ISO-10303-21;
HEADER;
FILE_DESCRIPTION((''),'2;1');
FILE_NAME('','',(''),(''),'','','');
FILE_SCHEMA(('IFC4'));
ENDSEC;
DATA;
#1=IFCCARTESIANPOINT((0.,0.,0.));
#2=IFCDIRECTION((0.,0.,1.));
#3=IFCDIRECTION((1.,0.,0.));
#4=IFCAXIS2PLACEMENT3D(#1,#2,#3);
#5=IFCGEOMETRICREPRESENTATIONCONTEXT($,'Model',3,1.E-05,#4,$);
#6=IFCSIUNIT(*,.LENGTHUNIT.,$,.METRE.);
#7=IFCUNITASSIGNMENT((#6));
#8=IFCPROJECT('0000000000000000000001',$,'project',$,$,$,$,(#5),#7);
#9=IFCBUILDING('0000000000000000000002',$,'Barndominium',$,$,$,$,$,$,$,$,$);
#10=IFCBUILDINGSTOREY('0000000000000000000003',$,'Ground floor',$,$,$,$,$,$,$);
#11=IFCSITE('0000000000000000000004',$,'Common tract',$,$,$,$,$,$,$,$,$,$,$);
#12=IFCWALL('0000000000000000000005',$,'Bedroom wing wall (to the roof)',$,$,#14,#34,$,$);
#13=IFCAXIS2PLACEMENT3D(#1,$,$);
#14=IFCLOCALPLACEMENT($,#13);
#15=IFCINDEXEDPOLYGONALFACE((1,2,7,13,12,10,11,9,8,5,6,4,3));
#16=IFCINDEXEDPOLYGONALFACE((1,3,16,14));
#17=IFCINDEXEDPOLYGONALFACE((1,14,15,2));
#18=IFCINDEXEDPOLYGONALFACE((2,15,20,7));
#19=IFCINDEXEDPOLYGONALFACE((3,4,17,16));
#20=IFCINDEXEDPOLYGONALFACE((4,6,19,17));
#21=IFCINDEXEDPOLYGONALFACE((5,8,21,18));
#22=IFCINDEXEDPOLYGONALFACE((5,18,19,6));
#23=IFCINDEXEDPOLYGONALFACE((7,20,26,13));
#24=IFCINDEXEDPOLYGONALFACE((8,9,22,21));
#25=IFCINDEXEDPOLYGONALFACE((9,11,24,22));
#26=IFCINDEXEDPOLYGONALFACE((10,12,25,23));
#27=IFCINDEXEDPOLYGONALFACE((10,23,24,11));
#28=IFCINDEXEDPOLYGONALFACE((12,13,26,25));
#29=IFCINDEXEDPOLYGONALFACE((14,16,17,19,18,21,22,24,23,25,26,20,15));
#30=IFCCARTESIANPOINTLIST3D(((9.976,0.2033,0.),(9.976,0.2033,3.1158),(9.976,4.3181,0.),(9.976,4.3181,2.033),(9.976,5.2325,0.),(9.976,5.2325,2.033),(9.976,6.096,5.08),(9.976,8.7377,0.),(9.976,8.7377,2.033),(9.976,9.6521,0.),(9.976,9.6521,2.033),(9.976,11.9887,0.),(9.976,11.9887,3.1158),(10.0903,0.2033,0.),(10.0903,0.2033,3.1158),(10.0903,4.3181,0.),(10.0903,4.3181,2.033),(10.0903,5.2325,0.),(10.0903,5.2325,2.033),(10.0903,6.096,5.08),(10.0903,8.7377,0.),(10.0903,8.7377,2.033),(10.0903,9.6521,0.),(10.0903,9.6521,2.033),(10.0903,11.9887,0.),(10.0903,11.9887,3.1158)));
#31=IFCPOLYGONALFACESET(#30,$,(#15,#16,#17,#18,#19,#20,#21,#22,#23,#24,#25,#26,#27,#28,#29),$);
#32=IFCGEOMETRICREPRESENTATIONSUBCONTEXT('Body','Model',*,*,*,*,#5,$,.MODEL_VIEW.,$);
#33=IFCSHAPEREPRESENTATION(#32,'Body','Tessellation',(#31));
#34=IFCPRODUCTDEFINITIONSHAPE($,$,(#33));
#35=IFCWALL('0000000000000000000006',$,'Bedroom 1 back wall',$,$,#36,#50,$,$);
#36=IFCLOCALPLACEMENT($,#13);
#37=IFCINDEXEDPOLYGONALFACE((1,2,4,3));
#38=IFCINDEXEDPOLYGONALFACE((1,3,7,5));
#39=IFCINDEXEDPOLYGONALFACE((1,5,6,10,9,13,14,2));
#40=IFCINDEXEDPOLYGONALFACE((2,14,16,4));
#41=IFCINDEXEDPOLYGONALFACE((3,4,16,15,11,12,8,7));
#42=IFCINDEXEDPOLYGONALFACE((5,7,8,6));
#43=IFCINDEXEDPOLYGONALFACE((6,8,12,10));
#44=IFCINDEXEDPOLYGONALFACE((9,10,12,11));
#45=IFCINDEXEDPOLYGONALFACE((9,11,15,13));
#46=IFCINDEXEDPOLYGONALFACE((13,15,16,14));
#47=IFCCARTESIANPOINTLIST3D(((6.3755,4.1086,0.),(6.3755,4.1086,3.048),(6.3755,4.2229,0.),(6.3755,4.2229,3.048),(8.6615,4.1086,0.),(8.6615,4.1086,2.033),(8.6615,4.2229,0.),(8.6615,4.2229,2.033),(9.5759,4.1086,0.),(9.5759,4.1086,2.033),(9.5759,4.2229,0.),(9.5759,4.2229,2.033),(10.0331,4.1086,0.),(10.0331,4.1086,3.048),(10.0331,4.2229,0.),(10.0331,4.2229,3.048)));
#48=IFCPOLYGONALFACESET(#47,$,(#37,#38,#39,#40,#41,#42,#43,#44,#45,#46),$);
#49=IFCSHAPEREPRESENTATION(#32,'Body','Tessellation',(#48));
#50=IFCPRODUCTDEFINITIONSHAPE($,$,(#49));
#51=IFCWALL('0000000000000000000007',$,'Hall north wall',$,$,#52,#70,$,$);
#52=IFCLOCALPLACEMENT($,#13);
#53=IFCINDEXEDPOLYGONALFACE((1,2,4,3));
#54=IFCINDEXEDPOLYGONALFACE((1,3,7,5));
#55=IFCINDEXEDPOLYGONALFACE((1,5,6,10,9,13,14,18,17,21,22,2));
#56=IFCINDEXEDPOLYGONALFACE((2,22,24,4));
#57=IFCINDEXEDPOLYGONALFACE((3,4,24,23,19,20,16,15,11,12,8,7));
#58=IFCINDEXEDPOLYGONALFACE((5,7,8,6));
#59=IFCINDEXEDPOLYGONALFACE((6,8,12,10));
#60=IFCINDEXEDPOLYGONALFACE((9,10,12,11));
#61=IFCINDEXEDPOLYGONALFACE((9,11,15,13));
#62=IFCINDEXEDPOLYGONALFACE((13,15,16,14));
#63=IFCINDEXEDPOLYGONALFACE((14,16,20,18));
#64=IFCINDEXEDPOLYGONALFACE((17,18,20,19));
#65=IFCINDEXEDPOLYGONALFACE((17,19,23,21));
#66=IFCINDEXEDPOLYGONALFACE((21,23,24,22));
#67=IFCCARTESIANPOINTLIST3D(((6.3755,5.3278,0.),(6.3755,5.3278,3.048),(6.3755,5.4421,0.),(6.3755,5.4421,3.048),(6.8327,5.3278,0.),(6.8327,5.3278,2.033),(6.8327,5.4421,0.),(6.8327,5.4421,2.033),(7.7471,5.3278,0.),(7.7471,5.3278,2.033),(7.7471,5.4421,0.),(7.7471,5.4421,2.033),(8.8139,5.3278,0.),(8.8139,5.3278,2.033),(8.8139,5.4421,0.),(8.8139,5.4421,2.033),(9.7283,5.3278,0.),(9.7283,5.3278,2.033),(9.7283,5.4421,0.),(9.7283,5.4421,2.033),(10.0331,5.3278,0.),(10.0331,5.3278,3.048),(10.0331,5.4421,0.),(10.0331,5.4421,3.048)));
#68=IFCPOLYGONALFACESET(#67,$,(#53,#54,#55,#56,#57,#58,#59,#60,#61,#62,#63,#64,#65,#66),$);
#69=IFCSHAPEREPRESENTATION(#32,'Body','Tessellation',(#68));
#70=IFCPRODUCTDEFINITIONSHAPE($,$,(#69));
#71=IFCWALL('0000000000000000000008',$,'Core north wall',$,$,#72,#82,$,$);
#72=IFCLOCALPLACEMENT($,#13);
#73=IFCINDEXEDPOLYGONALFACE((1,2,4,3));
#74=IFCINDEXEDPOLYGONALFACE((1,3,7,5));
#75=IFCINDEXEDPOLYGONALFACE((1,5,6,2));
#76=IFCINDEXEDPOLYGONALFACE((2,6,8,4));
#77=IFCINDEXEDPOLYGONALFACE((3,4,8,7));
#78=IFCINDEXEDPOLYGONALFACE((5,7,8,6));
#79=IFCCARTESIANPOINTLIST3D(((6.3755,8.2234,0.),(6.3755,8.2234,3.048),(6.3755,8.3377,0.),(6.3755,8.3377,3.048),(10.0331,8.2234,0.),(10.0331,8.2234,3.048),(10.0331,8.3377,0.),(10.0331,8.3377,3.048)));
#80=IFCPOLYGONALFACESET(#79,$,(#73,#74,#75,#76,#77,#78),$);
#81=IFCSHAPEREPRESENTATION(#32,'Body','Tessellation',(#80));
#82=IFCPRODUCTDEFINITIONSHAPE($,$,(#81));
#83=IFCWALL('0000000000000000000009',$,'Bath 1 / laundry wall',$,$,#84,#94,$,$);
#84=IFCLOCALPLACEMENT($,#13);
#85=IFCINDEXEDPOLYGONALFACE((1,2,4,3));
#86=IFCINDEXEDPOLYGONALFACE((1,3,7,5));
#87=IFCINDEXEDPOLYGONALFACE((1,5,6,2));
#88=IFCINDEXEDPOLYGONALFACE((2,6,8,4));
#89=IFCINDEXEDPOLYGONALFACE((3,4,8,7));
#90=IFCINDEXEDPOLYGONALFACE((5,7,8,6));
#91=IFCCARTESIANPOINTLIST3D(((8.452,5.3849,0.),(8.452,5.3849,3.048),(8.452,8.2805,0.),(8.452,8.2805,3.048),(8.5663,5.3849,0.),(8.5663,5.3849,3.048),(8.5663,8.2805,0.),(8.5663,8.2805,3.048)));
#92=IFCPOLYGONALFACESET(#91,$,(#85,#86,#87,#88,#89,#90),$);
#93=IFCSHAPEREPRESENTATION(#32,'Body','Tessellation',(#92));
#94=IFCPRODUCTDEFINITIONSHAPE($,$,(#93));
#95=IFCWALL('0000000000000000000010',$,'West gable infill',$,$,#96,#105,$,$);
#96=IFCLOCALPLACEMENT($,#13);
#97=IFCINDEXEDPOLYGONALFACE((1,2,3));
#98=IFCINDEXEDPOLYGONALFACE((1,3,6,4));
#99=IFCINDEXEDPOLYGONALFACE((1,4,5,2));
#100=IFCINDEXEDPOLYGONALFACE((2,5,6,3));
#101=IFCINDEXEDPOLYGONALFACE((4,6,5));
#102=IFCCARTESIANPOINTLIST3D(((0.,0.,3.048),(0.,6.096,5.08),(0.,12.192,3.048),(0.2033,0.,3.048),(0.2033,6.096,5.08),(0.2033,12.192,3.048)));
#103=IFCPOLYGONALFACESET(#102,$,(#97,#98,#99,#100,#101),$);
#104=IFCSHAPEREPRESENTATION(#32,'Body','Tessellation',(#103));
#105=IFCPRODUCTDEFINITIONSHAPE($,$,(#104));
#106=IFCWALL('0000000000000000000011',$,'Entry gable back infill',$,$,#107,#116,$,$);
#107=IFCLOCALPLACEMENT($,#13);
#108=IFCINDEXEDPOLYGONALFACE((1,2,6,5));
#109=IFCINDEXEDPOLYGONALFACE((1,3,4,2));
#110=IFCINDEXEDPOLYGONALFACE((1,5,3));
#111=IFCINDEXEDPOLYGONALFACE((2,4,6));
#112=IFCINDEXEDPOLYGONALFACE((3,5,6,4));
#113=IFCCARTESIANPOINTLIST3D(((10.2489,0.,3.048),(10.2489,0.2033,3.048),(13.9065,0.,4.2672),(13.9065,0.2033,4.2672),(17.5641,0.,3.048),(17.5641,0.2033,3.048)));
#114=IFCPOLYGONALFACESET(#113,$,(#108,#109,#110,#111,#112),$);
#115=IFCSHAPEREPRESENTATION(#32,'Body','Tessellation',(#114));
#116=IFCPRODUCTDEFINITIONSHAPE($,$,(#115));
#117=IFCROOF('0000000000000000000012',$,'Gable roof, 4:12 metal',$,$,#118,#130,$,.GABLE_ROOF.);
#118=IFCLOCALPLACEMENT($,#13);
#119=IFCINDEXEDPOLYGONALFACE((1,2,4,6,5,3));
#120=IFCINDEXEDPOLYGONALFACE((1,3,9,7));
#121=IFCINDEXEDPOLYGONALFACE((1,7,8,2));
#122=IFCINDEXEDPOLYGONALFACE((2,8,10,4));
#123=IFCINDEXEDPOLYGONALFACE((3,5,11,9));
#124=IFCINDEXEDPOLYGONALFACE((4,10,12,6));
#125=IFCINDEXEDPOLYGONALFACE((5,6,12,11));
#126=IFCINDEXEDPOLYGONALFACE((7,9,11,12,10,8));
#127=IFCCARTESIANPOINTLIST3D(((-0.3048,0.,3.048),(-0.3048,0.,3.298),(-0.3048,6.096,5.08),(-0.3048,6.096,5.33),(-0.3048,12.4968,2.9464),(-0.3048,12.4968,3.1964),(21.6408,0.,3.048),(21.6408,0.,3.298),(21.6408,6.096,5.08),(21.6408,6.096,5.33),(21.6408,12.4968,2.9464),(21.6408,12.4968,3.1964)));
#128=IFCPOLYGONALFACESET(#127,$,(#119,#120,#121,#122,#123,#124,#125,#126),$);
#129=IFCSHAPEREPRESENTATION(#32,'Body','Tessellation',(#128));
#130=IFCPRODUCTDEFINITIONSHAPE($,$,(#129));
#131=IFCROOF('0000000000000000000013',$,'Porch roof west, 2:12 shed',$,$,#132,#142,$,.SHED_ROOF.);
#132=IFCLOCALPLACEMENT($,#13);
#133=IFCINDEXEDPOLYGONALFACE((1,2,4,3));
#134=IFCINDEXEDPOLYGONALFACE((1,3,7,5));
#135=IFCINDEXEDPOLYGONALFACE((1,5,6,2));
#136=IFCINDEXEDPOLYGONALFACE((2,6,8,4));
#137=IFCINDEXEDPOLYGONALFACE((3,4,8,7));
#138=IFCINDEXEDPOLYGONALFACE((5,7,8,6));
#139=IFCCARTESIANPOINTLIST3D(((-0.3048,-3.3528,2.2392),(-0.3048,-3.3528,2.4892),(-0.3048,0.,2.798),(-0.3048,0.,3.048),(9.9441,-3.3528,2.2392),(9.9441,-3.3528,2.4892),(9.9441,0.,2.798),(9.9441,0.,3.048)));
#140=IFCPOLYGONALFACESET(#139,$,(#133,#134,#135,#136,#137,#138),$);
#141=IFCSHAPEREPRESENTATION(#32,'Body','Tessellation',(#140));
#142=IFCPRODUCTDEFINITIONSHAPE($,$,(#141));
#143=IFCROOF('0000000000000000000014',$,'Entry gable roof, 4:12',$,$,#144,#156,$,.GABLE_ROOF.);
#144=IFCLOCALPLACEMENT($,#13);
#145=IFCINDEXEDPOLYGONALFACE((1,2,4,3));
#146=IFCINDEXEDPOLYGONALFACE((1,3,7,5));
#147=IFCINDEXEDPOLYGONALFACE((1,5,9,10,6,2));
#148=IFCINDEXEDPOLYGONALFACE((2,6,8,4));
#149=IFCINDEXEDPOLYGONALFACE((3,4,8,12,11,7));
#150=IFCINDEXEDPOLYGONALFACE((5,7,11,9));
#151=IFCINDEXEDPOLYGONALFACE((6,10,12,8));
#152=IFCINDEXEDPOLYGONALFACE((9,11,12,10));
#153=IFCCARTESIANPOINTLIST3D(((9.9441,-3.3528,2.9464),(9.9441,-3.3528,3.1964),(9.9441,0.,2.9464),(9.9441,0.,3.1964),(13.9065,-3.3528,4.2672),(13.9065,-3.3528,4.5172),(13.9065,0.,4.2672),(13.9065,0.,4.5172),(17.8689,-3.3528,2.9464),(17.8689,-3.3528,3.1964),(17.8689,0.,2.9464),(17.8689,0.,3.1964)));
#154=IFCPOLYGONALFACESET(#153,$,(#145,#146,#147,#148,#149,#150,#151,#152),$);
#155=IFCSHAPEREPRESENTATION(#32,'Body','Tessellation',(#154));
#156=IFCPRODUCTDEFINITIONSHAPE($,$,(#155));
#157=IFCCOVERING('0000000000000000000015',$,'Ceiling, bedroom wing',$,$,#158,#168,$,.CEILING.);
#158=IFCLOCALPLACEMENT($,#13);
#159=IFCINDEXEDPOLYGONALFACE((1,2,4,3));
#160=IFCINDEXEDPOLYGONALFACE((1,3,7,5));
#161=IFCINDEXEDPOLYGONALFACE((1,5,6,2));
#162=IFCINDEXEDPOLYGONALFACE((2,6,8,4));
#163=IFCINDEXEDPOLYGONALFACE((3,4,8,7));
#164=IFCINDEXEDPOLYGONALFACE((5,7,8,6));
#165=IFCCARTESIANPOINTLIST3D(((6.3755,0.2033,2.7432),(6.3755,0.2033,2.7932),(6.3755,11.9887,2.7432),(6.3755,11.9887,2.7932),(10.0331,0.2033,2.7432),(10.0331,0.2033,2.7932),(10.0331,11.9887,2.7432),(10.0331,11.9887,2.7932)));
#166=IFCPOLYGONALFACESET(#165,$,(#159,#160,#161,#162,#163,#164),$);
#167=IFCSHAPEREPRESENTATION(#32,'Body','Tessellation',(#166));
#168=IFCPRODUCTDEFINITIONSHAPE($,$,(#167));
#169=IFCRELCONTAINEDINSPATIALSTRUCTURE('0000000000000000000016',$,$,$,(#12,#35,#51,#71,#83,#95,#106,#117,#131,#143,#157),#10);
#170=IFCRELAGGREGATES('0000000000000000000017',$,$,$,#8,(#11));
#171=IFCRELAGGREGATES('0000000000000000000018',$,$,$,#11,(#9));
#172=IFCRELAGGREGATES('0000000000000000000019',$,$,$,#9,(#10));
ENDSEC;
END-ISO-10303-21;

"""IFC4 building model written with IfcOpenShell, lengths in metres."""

from ifc_helpers import new_model, si_unit, frame, origin_with_axes, place, context, subcontext, project, spatial, polyline, indexed_curve, rectangle, outline, extrude, element, save


model = new_model("IFC4")

# Units and contexts
model_context = context("Model", 3, precision=1e-05, world=origin_with_axes())
body_context = subcontext(model_context, "Body", "Model", "MODEL_VIEW")
ifc_project = project(units=[si_unit("LENGTHUNIT", "METRE")], contexts=[model_context])

# Site, building, storey
site = spatial("IfcSite", under=ifc_project, Name="Common tract")
building = spatial("IfcBuilding", under=site, Name="Barndominium")
storey = spatial("IfcBuildingStorey", under=building, Name="Ground floor")

# Wall, openings
wall_1_placement = place(None, frame((9.976, 0.2033, 0.0), z_axis=(1.0, 0.0, 0.0), x_axis=(0.0, 1.0, 0.0)))
wall_1 = element("IfcWall", 1, at=wall_1_placement, inside=storey, Name="Bedroom wing wall (to the roof)", context=body_context, shape_type="SweptSolid", body=[
    extrude(outline(polyline([(0.0, 0.0), (11.7854, 0.0), (11.7854, 3.1158), (5.8927, 5.08), (0.0, 3.1158), (0.0, 0.0)])), origin_with_axes(), (0.0, 0.0, 1.0), 0.1143),
])
opening_1_placement = place(wall_1_placement, frame((4.572, 0.0, 0.0572), z_axis=(0.0, 1.0, 0.0), x_axis=(0.0, 0.0, 1.0)))
element("IfcOpeningElement", 2, at=opening_1_placement, cuts=wall_1, context=body_context, shape_type="SweptSolid", body=[
    extrude(rectangle(XDim=0.3033, YDim=0.9144), origin_with_axes(), (0.0, 0.0, 1.0), 2.033),
])
opening_2_placement = place(wall_1_placement, frame((8.9916, 0.0, 0.0572), z_axis=(0.0, 1.0, 0.0), x_axis=(0.0, 0.0, 1.0)))
element("IfcOpeningElement", 3, at=opening_2_placement, cuts=wall_1, context=body_context, shape_type="SweptSolid", body=[
    extrude(rectangle(XDim=0.3033, YDim=0.9144), origin_with_axes(), (0.0, 0.0, 1.0), 2.033),
])

# Wall, opening
wall_2_placement = place(None, frame((6.3755, 4.1086, 0.0), z_axis=(0.0, 0.0, 1.0), x_axis=(1.0, 0.0, 0.0)))
wall_2 = element("IfcWall", 4, at=wall_2_placement, inside=storey, Name="Bedroom 1 back wall", context=body_context, shape_type="SweptSolid", body=[
    extrude(outline(indexed_curve([(0.0, 0.0), (0.0, 0.1143), (3.6576, 0.1143), (3.6576, 0.0), (0.0, 0.0)], self_intersect=False)), origin_with_axes(), (0.0, 0.0, 1.0), 3.048),
])
opening_3_placement = place(wall_2_placement, frame((2.7432, 0.0572, 0.0), z_axis=(0.0, 0.0, 1.0), x_axis=(1.0, 0.0, 0.0)))
element("IfcOpeningElement", 5, at=opening_3_placement, cuts=wall_2, context=body_context, shape_type="SweptSolid", body=[
    extrude(rectangle(XDim=0.9144, YDim=0.3033), origin_with_axes(), (0.0, 0.0, 1.0), 2.033),
])

# Wall, openings
wall_3_placement = place(None, frame((6.3755, 5.3278, 0.0), z_axis=(0.0, 0.0, 1.0), x_axis=(1.0, 0.0, 0.0)))
wall_3 = element("IfcWall", 6, at=wall_3_placement, inside=storey, Name="Hall north wall", context=body_context, shape_type="SweptSolid", body=[
    extrude(outline(indexed_curve([(0.0, 0.0), (0.0, 0.1143), (3.6576, 0.1143), (3.6576, 0.0), (0.0, 0.0)], self_intersect=False)), origin_with_axes(), (0.0, 0.0, 1.0), 3.048),
])
opening_4_placement = place(wall_3_placement, frame((0.9144, 0.0572, 0.0), z_axis=(0.0, 0.0, 1.0), x_axis=(1.0, 0.0, 0.0)))
element("IfcOpeningElement", 7, at=opening_4_placement, cuts=wall_3, context=body_context, shape_type="SweptSolid", body=[
    extrude(rectangle(XDim=0.9144, YDim=0.3033), origin_with_axes(), (0.0, 0.0, 1.0), 2.033),
])
opening_5_placement = place(wall_3_placement, frame((2.8956, 0.0572, 0.0), z_axis=(0.0, 0.0, 1.0), x_axis=(1.0, 0.0, 0.0)))
element("IfcOpeningElement", 8, at=opening_5_placement, cuts=wall_3, context=body_context, shape_type="SweptSolid", body=[
    extrude(rectangle(XDim=0.9144, YDim=0.3033), origin_with_axes(), (0.0, 0.0, 1.0), 2.033),
])

# Walls
wall_4_placement = place(None, frame((6.3755, 8.2234, 0.0), z_axis=(0.0, 0.0, 1.0), x_axis=(1.0, 0.0, 0.0)))
element("IfcWall", 9, at=wall_4_placement, inside=storey, Name="Core north wall", context=body_context, shape_type="SweptSolid", body=[
    extrude(outline(indexed_curve([(0.0, 0.0), (0.0, 0.1143), (3.6576, 0.1143), (3.6576, 0.0), (0.0, 0.0)], self_intersect=False)), origin_with_axes(), (0.0, 0.0, 1.0), 3.048),
])
wall_5_placement = place(None, frame((8.5663, 5.3849, 0.0), z_axis=(0.0, 0.0, 1.0), x_axis=(0.0, 1.0, 0.0)))
element("IfcWall", 10, at=wall_5_placement, inside=storey, Name="Bath 1 / laundry wall", context=body_context, shape_type="SweptSolid", body=[
    extrude(outline(indexed_curve([(0.0, 0.0), (0.0, 0.1143), (2.8956, 0.1143), (2.8956, 0.0), (0.0, 0.0)], self_intersect=False)), origin_with_axes(), (0.0, 0.0, 1.0), 3.048),
])
wall_6_placement = place(None, frame((0.0, 0.0, 0.0), z_axis=(1.0, 0.0, 0.0), x_axis=(0.0, 1.0, 0.0)))
element("IfcWall", 11, at=wall_6_placement, inside=storey, Name="West gable infill", context=body_context, shape_type="SweptSolid", body=[
    extrude(outline(polyline([(0.0, 3.048), (12.192, 3.048), (6.096, 5.08), (0.0, 3.048)])), origin_with_axes(), (0.0, 0.0, 1.0), 0.2033),
])
wall_7_placement = place(None, frame((0.0, 0.2033, 0.0), z_axis=(0.0, -1.0, 0.0), x_axis=(1.0, 0.0, 0.0)))
element("IfcWall", 12, at=wall_7_placement, inside=storey, Name="Entry gable back infill", context=body_context, shape_type="SweptSolid", body=[
    extrude(outline(polyline([(10.2489, 3.048), (17.5641, 3.048), (13.9065, 4.2672), (10.2489, 3.048)])), origin_with_axes(), (0.0, 0.0, 1.0), 0.2033),
])

# Roofs
roof_1_placement = place(None, frame((-0.3048, 0.0, 0.0), z_axis=(1.0, 0.0, 0.0), x_axis=(0.0, 1.0, 0.0)))
element("IfcRoof", 13, at=roof_1_placement, inside=storey, Name="Gable roof, 4:12 metal", PredefinedType="GABLE_ROOF", context=body_context, shape_type="SweptSolid", body=[
    extrude(outline(polyline([(0.0, 3.048), (6.096, 5.08), (12.4968, 2.9464), (12.4968, 3.1964), (6.096, 5.33), (0.0, 3.298), (0.0, 3.048)])), origin_with_axes(), (0.0, 0.0, 1.0), 21.9456),
])
roof_2_placement = place(None, frame((-0.3048, 0.0, 0.0), z_axis=(1.0, 0.0, 0.0), x_axis=(0.0, 1.0, 0.0)))
element("IfcRoof", 14, at=roof_2_placement, inside=storey, Name="Porch roof west, 2:12 shed", PredefinedType="SHED_ROOF", context=body_context, shape_type="SweptSolid", body=[
    extrude(outline(polyline([(0.0, 2.798), (-3.3528, 2.2392), (-3.3528, 2.4892), (0.0, 3.048), (0.0, 2.798)])), origin_with_axes(), (0.0, 0.0, 1.0), 10.2489),
])
roof_3_placement = place(None, frame((0.0, 0.0, 0.0), z_axis=(0.0, -1.0, 0.0), x_axis=(1.0, 0.0, 0.0)))
element("IfcRoof", 15, at=roof_3_placement, inside=storey, Name="Entry gable roof, 4:12", PredefinedType="GABLE_ROOF", context=body_context, shape_type="SweptSolid", body=[
    extrude(outline(polyline([(9.9441, 2.9464), (13.9065, 4.2672), (17.8689, 2.9464), (17.8689, 3.1964), (13.9065, 4.5172), (9.9441, 3.1964), (9.9441, 2.9464)])), origin_with_axes(), (0.0, 0.0, 1.0), 3.3528),
])

# Covering
covering_placement = place(None, frame((8.2043, 6.096, 2.7432), z_axis=(0.0, 0.0, 1.0), x_axis=(1.0, 0.0, 0.0)))
element("IfcCovering", 16, at=covering_placement, inside=storey, Name="Ceiling, bedroom wing", PredefinedType="CEILING", context=body_context, shape_type="SweptSolid", body=[
    extrude(rectangle(XDim=3.6576, YDim=11.7854), origin_with_axes(), (0.0, 0.0, 1.0), 0.05),
])

save(model, "model.ifc")
